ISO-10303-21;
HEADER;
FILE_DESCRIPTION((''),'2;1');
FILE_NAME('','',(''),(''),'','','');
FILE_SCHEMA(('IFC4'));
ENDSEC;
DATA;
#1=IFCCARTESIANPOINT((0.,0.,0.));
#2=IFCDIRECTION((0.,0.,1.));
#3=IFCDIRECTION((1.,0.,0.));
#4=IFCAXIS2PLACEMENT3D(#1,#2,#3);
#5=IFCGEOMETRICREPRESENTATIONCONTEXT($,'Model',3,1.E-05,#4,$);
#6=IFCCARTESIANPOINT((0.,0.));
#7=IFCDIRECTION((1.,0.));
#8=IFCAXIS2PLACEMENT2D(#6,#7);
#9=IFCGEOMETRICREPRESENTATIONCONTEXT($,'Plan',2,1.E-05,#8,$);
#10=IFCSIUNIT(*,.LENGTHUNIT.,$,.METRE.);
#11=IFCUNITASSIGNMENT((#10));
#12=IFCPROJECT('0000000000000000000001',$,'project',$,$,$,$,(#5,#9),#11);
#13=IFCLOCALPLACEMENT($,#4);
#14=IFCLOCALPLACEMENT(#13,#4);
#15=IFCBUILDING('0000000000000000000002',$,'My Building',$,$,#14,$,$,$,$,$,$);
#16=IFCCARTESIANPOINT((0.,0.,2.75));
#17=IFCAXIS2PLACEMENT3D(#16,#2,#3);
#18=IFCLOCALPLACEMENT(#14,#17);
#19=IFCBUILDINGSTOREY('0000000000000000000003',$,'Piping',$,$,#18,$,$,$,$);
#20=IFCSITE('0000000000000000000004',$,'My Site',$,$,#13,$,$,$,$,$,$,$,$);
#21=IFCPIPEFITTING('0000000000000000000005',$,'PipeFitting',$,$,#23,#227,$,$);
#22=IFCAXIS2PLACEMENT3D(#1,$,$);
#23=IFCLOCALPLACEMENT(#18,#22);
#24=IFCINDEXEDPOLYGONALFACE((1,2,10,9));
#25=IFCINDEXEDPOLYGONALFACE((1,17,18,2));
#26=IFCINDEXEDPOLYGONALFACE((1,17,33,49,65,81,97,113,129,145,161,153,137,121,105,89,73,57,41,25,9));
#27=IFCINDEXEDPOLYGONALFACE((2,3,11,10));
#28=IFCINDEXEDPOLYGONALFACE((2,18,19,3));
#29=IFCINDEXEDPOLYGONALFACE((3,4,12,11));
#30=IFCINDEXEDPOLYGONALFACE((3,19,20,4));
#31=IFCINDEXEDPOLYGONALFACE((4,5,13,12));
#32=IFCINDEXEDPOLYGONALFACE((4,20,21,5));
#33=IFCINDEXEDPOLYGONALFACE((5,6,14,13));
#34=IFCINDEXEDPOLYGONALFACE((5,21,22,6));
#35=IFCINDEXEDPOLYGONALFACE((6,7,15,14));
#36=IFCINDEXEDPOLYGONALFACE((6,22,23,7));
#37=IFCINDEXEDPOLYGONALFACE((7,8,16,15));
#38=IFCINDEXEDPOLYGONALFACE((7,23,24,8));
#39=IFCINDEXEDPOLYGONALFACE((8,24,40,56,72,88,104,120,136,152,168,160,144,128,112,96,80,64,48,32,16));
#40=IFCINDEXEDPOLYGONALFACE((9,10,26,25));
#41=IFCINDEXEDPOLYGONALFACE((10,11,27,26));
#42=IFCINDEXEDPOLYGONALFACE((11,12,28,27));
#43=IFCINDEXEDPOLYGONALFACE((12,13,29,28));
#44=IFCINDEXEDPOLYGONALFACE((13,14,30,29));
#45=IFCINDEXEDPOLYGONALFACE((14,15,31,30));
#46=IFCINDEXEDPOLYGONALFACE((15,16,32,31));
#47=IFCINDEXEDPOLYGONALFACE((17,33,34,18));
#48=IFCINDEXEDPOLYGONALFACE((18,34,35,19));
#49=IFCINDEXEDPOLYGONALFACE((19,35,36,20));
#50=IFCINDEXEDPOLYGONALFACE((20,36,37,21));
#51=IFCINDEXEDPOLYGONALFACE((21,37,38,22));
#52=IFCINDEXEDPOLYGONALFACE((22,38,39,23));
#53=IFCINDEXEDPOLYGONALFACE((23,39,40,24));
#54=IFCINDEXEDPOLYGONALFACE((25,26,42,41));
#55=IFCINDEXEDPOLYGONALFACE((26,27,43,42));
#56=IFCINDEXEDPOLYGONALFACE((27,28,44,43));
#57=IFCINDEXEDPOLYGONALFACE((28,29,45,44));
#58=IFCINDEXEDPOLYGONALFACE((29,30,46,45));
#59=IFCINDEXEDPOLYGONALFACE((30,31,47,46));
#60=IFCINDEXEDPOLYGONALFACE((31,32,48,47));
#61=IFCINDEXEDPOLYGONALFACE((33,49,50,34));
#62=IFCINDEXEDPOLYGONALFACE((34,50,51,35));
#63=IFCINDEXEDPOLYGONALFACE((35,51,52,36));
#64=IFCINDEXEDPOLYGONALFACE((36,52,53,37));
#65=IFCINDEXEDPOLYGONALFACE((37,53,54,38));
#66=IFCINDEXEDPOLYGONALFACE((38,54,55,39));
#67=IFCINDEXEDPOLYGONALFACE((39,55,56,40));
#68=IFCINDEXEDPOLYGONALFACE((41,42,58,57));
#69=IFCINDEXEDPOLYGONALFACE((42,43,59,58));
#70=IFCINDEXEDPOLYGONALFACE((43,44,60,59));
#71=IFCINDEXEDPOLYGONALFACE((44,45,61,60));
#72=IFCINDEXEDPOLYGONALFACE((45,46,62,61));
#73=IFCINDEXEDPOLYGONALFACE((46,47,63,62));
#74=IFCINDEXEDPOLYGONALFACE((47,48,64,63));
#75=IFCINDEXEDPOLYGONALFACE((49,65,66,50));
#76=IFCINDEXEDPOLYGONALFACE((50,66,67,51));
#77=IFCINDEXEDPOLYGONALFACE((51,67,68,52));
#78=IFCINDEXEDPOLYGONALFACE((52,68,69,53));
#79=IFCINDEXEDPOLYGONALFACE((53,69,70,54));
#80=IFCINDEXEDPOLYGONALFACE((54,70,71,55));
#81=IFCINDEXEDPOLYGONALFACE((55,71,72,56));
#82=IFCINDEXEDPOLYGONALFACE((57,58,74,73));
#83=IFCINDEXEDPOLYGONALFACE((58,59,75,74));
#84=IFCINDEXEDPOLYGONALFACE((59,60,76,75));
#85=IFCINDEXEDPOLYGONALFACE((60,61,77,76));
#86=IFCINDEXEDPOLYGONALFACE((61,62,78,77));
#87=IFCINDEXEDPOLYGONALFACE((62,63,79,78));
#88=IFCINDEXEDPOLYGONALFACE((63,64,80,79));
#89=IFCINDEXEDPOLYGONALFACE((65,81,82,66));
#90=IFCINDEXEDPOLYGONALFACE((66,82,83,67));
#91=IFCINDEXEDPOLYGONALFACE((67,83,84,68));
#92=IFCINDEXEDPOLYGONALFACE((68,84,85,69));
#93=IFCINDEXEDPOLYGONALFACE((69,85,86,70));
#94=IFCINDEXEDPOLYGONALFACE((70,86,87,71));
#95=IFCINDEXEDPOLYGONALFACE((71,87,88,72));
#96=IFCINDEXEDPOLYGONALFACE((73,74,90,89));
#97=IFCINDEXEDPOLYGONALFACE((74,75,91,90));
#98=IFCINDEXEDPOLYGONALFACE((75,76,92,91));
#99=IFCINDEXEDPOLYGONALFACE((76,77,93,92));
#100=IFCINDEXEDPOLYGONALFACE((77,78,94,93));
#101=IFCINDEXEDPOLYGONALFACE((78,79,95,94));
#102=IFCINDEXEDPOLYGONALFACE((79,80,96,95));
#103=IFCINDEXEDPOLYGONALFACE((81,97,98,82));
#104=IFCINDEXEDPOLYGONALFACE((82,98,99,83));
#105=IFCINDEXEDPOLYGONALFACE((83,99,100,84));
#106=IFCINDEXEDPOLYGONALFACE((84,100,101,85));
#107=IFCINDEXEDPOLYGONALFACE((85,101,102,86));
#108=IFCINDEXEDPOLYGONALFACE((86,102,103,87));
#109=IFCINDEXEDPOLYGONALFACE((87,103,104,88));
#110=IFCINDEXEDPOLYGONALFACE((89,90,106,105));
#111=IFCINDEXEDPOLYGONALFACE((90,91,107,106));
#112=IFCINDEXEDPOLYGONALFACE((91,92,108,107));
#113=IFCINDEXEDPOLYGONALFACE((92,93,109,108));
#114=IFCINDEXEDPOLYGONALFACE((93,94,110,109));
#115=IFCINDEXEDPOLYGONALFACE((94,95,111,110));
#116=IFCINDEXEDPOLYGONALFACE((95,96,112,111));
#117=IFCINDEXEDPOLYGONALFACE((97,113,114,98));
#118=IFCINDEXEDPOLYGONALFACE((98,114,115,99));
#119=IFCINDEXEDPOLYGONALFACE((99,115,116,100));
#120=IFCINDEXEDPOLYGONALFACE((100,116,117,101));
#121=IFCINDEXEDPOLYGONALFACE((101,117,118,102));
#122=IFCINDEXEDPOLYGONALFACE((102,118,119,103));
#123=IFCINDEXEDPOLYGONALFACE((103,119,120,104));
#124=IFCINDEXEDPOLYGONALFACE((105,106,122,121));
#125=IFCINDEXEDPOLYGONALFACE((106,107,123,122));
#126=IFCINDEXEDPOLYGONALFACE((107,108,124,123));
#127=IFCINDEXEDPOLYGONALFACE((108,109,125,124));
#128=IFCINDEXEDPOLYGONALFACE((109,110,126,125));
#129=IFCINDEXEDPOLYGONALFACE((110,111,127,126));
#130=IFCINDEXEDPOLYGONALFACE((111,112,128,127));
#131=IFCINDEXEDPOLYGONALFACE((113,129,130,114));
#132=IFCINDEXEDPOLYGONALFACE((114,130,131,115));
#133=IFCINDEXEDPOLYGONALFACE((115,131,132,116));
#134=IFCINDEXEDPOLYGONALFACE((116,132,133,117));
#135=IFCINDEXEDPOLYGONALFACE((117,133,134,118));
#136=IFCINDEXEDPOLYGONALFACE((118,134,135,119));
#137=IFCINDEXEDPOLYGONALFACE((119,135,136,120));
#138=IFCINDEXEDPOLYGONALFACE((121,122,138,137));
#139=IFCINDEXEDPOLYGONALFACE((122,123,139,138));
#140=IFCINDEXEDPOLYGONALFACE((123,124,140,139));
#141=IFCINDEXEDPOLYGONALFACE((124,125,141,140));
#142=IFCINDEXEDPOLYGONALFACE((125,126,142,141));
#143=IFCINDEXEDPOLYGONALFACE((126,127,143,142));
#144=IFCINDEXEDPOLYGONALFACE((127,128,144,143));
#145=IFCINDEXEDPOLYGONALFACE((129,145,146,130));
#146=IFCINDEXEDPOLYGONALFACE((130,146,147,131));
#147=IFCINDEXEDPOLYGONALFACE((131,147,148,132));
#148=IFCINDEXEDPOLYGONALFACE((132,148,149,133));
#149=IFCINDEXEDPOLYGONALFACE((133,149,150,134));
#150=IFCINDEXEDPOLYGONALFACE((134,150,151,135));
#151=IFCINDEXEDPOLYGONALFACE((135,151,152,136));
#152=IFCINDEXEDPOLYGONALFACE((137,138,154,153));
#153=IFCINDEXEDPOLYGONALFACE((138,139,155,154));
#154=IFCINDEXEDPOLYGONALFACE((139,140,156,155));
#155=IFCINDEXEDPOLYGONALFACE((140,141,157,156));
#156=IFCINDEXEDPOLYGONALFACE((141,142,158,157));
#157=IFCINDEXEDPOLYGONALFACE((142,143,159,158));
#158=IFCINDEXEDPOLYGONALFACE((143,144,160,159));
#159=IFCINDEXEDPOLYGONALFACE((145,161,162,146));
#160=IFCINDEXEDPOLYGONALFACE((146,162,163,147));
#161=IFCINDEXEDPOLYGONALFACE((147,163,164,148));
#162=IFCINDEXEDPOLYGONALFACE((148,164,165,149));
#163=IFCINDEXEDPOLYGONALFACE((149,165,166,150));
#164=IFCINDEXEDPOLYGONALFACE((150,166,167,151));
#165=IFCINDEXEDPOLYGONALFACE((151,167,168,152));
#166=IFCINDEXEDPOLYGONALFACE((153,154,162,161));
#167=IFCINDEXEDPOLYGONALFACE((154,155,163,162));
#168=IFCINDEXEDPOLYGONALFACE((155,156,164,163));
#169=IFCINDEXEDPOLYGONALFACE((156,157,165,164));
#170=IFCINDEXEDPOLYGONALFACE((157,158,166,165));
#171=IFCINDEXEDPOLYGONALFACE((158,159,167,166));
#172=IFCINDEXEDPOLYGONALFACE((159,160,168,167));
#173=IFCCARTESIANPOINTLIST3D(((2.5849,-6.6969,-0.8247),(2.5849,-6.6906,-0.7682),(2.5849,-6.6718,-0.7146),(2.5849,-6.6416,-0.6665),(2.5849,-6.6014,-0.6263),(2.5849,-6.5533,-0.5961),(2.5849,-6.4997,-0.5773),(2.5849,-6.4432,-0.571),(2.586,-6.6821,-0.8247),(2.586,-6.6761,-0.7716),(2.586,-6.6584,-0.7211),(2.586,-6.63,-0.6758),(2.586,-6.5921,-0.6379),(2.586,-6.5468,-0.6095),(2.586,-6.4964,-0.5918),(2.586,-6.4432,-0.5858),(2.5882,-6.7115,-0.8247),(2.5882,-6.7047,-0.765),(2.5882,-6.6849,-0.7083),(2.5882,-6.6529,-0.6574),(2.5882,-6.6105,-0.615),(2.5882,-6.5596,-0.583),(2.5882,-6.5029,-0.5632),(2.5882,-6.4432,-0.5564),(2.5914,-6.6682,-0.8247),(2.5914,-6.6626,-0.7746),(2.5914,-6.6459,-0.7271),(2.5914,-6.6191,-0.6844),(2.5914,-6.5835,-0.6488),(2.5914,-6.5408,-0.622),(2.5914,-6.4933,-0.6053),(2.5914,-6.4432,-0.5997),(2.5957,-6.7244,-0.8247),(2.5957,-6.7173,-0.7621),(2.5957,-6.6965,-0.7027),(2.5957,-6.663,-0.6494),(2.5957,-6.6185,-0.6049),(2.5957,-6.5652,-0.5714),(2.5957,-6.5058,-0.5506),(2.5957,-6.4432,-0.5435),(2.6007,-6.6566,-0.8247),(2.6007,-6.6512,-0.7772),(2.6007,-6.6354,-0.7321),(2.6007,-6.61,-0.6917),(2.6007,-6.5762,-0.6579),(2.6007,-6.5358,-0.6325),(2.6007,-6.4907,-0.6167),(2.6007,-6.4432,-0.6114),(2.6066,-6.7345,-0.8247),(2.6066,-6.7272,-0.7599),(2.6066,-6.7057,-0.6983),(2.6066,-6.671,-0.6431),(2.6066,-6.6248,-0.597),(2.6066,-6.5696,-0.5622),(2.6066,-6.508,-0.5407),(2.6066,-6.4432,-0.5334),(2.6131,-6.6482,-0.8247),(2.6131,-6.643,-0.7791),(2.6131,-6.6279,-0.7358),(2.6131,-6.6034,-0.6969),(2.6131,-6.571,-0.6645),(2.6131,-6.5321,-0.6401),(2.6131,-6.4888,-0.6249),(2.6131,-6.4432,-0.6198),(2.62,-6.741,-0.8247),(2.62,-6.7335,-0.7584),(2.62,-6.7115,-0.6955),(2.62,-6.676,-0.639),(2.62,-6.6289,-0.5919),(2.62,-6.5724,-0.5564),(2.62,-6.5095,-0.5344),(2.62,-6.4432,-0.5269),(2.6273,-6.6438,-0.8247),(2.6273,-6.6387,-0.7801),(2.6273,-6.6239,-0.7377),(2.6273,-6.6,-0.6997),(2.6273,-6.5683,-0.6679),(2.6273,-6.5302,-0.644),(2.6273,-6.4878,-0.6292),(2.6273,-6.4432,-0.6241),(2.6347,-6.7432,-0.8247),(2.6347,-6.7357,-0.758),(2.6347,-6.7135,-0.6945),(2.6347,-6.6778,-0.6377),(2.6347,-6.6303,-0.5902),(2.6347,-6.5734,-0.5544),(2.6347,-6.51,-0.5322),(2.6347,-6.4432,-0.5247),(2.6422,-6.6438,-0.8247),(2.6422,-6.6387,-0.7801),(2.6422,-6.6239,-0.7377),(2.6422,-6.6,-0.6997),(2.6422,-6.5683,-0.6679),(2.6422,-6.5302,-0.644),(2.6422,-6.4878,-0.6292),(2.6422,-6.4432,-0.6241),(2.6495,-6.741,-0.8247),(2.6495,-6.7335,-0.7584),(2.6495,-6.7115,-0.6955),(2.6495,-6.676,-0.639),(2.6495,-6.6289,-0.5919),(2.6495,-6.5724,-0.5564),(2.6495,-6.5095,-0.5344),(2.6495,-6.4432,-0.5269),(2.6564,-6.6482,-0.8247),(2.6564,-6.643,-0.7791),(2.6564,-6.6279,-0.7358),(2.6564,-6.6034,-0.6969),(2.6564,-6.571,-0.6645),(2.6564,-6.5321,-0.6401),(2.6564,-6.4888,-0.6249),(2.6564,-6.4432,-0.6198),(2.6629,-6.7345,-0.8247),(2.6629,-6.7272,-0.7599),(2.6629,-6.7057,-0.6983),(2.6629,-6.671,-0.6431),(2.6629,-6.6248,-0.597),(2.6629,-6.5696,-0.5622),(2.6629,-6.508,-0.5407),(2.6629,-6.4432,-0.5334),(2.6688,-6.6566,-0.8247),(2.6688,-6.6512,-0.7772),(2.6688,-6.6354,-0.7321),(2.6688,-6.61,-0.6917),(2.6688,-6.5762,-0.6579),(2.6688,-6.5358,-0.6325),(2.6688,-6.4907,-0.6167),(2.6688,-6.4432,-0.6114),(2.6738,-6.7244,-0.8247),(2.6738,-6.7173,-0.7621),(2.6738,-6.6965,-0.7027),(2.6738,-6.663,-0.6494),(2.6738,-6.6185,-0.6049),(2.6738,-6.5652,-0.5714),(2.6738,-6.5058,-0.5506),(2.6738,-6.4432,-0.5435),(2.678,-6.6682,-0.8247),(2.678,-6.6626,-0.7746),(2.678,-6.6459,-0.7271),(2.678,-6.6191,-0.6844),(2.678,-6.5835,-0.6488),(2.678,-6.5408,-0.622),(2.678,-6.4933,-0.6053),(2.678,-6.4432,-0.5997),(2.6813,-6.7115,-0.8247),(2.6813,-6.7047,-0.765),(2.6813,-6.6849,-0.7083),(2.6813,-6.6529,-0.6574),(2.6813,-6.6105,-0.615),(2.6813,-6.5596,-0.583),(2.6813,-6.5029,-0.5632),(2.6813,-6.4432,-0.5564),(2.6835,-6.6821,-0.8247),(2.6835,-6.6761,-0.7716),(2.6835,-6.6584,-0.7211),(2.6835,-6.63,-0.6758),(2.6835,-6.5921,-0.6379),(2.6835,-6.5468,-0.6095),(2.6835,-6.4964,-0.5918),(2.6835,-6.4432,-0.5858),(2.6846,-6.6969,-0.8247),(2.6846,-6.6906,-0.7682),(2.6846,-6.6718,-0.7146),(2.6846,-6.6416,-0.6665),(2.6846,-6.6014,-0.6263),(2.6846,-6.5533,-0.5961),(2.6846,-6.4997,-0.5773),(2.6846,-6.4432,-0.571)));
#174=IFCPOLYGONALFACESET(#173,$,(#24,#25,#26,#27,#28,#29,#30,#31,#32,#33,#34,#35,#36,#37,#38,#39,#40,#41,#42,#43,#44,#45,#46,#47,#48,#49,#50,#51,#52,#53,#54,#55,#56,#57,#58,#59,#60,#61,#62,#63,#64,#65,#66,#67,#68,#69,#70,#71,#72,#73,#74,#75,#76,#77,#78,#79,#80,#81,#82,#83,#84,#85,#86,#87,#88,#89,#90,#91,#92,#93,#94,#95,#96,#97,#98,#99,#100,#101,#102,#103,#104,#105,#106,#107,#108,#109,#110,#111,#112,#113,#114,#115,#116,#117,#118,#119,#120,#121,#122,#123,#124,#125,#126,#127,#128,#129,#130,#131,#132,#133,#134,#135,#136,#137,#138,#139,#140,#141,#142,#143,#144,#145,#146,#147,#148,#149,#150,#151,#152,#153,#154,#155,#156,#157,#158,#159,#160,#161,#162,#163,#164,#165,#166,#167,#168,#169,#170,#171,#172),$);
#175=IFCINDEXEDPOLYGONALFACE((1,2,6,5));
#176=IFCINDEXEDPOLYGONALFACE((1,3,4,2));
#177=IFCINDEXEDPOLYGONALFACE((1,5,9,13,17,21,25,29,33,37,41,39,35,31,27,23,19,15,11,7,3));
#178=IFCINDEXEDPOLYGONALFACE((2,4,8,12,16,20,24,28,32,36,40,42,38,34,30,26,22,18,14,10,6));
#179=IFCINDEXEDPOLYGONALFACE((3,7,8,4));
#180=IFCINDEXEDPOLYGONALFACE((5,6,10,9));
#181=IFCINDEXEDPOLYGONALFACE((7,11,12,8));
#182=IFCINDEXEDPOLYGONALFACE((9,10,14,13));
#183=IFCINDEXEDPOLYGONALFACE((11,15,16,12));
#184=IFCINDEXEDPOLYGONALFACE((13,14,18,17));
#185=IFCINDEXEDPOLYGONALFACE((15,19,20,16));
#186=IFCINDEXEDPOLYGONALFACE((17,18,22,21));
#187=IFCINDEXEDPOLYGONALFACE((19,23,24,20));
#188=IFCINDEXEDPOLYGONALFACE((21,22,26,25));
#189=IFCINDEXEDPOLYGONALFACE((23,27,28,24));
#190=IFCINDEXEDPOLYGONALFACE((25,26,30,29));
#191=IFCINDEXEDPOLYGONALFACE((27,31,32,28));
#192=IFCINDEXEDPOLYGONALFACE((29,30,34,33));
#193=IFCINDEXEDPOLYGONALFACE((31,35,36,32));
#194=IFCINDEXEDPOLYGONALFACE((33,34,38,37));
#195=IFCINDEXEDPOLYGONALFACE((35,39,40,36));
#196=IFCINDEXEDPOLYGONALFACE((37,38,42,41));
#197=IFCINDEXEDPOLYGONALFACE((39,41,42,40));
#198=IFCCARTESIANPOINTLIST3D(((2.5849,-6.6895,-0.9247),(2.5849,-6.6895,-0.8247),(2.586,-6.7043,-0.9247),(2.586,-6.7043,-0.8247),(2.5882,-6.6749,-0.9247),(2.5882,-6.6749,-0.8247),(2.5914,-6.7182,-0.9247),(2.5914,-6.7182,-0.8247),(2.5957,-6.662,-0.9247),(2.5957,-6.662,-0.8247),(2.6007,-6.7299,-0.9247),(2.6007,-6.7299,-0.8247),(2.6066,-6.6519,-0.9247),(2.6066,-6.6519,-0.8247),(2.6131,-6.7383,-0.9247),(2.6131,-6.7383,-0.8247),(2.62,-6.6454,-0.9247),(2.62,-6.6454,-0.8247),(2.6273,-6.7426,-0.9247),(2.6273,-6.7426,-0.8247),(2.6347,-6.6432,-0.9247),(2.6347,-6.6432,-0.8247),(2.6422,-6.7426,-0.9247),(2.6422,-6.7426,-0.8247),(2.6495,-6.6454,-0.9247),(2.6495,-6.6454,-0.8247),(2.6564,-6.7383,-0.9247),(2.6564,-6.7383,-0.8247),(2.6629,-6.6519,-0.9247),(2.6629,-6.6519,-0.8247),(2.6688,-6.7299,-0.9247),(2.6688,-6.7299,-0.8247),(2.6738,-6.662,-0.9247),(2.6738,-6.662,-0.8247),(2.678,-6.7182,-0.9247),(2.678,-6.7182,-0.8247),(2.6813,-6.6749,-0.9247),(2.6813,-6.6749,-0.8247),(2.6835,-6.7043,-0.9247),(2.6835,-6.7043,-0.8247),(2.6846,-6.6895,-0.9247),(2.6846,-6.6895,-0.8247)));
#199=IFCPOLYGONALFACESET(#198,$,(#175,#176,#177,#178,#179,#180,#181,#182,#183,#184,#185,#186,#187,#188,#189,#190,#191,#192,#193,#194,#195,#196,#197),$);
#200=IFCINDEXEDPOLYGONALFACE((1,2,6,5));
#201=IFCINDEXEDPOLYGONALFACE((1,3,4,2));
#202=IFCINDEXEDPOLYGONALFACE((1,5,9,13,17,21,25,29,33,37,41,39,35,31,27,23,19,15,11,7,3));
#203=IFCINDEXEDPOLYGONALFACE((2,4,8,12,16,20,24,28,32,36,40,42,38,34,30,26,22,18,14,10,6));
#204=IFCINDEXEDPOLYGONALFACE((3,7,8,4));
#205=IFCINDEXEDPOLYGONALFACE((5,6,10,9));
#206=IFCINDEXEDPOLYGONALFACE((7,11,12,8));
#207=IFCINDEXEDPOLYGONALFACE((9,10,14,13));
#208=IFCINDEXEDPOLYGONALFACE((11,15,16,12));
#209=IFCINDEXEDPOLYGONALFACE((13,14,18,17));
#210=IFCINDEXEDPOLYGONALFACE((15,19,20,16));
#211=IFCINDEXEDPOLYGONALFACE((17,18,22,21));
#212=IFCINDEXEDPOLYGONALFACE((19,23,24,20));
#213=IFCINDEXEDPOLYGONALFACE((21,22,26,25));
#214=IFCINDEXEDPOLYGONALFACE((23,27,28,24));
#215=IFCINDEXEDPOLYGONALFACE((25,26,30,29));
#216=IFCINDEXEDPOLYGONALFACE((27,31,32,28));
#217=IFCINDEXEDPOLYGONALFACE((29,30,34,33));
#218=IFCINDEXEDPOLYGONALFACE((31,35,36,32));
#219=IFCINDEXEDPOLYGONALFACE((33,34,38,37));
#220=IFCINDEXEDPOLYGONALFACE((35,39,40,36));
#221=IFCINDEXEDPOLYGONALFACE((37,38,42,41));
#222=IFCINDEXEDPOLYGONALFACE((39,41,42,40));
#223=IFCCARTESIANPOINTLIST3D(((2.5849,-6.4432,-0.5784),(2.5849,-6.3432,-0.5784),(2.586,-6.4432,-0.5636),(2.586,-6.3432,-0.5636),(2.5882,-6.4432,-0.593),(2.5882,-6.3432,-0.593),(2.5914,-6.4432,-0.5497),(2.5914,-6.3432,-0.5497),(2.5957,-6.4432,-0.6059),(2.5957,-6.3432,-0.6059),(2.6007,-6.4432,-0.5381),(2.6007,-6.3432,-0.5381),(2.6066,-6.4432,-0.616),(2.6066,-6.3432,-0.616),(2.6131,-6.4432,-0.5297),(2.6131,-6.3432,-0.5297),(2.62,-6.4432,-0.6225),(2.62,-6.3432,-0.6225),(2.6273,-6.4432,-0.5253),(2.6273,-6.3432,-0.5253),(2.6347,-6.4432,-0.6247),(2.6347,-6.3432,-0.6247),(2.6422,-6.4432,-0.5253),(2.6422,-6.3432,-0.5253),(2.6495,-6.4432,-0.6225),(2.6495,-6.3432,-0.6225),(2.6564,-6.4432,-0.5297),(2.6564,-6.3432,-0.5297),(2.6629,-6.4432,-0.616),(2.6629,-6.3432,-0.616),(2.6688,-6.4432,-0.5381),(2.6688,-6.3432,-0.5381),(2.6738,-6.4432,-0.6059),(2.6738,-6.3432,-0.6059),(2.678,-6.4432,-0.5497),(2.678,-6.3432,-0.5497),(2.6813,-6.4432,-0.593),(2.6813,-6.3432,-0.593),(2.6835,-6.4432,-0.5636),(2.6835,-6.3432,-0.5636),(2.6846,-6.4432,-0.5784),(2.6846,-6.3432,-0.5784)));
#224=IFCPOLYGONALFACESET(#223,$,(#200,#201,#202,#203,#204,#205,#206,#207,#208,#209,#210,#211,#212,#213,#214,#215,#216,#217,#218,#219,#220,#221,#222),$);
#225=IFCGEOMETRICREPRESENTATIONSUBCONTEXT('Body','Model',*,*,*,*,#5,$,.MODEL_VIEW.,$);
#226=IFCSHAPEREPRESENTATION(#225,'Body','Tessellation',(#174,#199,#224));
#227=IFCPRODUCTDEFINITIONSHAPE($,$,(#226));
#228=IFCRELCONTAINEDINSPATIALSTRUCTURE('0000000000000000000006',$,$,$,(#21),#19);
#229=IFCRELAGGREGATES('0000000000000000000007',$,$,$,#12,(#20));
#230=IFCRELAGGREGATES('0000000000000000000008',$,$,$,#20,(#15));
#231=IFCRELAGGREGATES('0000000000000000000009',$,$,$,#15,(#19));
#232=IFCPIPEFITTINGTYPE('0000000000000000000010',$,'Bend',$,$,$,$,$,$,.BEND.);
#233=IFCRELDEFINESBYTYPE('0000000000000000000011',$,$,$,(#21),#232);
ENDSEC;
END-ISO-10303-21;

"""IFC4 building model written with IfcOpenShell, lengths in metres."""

from ifc_helpers import new_model, entity, si_unit, frame, origin_with_axes, origin_2d_with_axis, place, context, subcontext, project, spatial, circle, extrude, source, transform, mapped, type_object, type_shapes, element, save


model = new_model("IFC4")

# Units and contexts
model_context = context("Model", 3, precision=1e-05, world=origin_with_axes())
plan_context = context("Plan", 2, precision=1e-05, world=origin_2d_with_axis())
body_context = subcontext(model_context, "Body", "Model", "MODEL_VIEW")
ifc_project = project(units=[si_unit("LENGTHUNIT", "METRE")], contexts=[model_context, plan_context])

# Site, building, storey
site_placement = place(None, origin_with_axes())
site = spatial("IfcSite", under=ifc_project, at=site_placement, Name="My Site")
building_placement = place(site_placement, origin_with_axes())
building = spatial("IfcBuilding", under=site, at=building_placement, Name="My Building")
storey_placement = place(building_placement, frame((0.0, 0.0, 2.75), z_axis=(0.0, 0.0, 1.0), x_axis=(1.0, 0.0, 0.0)))
storey = spatial("IfcBuildingStorey", under=building, at=storey_placement, Name="Piping")

# Pipe fitting
pipe_fitting_type = type_object("IfcPipeFittingType", Name="Bend", PredefinedType="BEND")
shared_shape = source(origin_with_axes(), body_context, "Body", "SolidModel", [
    entity("IfcSweptDiskSolid", entity("IfcIndexedPolyCurve", entity("IfcCartesianPointList3D", [[0.0, 0.0, -0.1], [0.0732, 0.0, -0.2768], [0.25, 0.0, -0.35]]), [entity("IfcArcIndex", [1, 2, 3])]), 0.05),
    extrude(circle(Radius=0.05), origin_with_axes(), (0.0, 0.0, -1.0), 0.1),
    extrude(circle(Radius=0.05), frame((0.25, 0.0, -0.35), z_axis=(1.0, 0.0, 0.0), x_axis=(0.0, 0.0, 1.0)), (0.0, 0.0, 1.0), 0.1),
])
type_shapes(pipe_fitting_type, [shared_shape])
for number, where, z_axis, x_axis, name in (
    (1, (2.6347, -6.6932, -0.9247), (0.0, 0.0, -1.0), (0.0, 1.0, 0.0), "PipeFitting"),
):
    element("IfcPipeFitting", number, at=place(storey_placement, frame(where, z_axis=z_axis, x_axis=x_axis)), inside=storey, type_object=pipe_fitting_type, Name=name, context=body_context, shape_type="MappedRepresentation", body=[
        mapped(shared_shape, transform((0.0, 0.0, 0.0), x_axis=(1.0, 0.0, 0.0), y_axis=(0.0, 1.0, 0.0), z_axis=(0.0, 0.0, 1.0), scale=1.0)),
    ])

save(model, "model.ifc")
